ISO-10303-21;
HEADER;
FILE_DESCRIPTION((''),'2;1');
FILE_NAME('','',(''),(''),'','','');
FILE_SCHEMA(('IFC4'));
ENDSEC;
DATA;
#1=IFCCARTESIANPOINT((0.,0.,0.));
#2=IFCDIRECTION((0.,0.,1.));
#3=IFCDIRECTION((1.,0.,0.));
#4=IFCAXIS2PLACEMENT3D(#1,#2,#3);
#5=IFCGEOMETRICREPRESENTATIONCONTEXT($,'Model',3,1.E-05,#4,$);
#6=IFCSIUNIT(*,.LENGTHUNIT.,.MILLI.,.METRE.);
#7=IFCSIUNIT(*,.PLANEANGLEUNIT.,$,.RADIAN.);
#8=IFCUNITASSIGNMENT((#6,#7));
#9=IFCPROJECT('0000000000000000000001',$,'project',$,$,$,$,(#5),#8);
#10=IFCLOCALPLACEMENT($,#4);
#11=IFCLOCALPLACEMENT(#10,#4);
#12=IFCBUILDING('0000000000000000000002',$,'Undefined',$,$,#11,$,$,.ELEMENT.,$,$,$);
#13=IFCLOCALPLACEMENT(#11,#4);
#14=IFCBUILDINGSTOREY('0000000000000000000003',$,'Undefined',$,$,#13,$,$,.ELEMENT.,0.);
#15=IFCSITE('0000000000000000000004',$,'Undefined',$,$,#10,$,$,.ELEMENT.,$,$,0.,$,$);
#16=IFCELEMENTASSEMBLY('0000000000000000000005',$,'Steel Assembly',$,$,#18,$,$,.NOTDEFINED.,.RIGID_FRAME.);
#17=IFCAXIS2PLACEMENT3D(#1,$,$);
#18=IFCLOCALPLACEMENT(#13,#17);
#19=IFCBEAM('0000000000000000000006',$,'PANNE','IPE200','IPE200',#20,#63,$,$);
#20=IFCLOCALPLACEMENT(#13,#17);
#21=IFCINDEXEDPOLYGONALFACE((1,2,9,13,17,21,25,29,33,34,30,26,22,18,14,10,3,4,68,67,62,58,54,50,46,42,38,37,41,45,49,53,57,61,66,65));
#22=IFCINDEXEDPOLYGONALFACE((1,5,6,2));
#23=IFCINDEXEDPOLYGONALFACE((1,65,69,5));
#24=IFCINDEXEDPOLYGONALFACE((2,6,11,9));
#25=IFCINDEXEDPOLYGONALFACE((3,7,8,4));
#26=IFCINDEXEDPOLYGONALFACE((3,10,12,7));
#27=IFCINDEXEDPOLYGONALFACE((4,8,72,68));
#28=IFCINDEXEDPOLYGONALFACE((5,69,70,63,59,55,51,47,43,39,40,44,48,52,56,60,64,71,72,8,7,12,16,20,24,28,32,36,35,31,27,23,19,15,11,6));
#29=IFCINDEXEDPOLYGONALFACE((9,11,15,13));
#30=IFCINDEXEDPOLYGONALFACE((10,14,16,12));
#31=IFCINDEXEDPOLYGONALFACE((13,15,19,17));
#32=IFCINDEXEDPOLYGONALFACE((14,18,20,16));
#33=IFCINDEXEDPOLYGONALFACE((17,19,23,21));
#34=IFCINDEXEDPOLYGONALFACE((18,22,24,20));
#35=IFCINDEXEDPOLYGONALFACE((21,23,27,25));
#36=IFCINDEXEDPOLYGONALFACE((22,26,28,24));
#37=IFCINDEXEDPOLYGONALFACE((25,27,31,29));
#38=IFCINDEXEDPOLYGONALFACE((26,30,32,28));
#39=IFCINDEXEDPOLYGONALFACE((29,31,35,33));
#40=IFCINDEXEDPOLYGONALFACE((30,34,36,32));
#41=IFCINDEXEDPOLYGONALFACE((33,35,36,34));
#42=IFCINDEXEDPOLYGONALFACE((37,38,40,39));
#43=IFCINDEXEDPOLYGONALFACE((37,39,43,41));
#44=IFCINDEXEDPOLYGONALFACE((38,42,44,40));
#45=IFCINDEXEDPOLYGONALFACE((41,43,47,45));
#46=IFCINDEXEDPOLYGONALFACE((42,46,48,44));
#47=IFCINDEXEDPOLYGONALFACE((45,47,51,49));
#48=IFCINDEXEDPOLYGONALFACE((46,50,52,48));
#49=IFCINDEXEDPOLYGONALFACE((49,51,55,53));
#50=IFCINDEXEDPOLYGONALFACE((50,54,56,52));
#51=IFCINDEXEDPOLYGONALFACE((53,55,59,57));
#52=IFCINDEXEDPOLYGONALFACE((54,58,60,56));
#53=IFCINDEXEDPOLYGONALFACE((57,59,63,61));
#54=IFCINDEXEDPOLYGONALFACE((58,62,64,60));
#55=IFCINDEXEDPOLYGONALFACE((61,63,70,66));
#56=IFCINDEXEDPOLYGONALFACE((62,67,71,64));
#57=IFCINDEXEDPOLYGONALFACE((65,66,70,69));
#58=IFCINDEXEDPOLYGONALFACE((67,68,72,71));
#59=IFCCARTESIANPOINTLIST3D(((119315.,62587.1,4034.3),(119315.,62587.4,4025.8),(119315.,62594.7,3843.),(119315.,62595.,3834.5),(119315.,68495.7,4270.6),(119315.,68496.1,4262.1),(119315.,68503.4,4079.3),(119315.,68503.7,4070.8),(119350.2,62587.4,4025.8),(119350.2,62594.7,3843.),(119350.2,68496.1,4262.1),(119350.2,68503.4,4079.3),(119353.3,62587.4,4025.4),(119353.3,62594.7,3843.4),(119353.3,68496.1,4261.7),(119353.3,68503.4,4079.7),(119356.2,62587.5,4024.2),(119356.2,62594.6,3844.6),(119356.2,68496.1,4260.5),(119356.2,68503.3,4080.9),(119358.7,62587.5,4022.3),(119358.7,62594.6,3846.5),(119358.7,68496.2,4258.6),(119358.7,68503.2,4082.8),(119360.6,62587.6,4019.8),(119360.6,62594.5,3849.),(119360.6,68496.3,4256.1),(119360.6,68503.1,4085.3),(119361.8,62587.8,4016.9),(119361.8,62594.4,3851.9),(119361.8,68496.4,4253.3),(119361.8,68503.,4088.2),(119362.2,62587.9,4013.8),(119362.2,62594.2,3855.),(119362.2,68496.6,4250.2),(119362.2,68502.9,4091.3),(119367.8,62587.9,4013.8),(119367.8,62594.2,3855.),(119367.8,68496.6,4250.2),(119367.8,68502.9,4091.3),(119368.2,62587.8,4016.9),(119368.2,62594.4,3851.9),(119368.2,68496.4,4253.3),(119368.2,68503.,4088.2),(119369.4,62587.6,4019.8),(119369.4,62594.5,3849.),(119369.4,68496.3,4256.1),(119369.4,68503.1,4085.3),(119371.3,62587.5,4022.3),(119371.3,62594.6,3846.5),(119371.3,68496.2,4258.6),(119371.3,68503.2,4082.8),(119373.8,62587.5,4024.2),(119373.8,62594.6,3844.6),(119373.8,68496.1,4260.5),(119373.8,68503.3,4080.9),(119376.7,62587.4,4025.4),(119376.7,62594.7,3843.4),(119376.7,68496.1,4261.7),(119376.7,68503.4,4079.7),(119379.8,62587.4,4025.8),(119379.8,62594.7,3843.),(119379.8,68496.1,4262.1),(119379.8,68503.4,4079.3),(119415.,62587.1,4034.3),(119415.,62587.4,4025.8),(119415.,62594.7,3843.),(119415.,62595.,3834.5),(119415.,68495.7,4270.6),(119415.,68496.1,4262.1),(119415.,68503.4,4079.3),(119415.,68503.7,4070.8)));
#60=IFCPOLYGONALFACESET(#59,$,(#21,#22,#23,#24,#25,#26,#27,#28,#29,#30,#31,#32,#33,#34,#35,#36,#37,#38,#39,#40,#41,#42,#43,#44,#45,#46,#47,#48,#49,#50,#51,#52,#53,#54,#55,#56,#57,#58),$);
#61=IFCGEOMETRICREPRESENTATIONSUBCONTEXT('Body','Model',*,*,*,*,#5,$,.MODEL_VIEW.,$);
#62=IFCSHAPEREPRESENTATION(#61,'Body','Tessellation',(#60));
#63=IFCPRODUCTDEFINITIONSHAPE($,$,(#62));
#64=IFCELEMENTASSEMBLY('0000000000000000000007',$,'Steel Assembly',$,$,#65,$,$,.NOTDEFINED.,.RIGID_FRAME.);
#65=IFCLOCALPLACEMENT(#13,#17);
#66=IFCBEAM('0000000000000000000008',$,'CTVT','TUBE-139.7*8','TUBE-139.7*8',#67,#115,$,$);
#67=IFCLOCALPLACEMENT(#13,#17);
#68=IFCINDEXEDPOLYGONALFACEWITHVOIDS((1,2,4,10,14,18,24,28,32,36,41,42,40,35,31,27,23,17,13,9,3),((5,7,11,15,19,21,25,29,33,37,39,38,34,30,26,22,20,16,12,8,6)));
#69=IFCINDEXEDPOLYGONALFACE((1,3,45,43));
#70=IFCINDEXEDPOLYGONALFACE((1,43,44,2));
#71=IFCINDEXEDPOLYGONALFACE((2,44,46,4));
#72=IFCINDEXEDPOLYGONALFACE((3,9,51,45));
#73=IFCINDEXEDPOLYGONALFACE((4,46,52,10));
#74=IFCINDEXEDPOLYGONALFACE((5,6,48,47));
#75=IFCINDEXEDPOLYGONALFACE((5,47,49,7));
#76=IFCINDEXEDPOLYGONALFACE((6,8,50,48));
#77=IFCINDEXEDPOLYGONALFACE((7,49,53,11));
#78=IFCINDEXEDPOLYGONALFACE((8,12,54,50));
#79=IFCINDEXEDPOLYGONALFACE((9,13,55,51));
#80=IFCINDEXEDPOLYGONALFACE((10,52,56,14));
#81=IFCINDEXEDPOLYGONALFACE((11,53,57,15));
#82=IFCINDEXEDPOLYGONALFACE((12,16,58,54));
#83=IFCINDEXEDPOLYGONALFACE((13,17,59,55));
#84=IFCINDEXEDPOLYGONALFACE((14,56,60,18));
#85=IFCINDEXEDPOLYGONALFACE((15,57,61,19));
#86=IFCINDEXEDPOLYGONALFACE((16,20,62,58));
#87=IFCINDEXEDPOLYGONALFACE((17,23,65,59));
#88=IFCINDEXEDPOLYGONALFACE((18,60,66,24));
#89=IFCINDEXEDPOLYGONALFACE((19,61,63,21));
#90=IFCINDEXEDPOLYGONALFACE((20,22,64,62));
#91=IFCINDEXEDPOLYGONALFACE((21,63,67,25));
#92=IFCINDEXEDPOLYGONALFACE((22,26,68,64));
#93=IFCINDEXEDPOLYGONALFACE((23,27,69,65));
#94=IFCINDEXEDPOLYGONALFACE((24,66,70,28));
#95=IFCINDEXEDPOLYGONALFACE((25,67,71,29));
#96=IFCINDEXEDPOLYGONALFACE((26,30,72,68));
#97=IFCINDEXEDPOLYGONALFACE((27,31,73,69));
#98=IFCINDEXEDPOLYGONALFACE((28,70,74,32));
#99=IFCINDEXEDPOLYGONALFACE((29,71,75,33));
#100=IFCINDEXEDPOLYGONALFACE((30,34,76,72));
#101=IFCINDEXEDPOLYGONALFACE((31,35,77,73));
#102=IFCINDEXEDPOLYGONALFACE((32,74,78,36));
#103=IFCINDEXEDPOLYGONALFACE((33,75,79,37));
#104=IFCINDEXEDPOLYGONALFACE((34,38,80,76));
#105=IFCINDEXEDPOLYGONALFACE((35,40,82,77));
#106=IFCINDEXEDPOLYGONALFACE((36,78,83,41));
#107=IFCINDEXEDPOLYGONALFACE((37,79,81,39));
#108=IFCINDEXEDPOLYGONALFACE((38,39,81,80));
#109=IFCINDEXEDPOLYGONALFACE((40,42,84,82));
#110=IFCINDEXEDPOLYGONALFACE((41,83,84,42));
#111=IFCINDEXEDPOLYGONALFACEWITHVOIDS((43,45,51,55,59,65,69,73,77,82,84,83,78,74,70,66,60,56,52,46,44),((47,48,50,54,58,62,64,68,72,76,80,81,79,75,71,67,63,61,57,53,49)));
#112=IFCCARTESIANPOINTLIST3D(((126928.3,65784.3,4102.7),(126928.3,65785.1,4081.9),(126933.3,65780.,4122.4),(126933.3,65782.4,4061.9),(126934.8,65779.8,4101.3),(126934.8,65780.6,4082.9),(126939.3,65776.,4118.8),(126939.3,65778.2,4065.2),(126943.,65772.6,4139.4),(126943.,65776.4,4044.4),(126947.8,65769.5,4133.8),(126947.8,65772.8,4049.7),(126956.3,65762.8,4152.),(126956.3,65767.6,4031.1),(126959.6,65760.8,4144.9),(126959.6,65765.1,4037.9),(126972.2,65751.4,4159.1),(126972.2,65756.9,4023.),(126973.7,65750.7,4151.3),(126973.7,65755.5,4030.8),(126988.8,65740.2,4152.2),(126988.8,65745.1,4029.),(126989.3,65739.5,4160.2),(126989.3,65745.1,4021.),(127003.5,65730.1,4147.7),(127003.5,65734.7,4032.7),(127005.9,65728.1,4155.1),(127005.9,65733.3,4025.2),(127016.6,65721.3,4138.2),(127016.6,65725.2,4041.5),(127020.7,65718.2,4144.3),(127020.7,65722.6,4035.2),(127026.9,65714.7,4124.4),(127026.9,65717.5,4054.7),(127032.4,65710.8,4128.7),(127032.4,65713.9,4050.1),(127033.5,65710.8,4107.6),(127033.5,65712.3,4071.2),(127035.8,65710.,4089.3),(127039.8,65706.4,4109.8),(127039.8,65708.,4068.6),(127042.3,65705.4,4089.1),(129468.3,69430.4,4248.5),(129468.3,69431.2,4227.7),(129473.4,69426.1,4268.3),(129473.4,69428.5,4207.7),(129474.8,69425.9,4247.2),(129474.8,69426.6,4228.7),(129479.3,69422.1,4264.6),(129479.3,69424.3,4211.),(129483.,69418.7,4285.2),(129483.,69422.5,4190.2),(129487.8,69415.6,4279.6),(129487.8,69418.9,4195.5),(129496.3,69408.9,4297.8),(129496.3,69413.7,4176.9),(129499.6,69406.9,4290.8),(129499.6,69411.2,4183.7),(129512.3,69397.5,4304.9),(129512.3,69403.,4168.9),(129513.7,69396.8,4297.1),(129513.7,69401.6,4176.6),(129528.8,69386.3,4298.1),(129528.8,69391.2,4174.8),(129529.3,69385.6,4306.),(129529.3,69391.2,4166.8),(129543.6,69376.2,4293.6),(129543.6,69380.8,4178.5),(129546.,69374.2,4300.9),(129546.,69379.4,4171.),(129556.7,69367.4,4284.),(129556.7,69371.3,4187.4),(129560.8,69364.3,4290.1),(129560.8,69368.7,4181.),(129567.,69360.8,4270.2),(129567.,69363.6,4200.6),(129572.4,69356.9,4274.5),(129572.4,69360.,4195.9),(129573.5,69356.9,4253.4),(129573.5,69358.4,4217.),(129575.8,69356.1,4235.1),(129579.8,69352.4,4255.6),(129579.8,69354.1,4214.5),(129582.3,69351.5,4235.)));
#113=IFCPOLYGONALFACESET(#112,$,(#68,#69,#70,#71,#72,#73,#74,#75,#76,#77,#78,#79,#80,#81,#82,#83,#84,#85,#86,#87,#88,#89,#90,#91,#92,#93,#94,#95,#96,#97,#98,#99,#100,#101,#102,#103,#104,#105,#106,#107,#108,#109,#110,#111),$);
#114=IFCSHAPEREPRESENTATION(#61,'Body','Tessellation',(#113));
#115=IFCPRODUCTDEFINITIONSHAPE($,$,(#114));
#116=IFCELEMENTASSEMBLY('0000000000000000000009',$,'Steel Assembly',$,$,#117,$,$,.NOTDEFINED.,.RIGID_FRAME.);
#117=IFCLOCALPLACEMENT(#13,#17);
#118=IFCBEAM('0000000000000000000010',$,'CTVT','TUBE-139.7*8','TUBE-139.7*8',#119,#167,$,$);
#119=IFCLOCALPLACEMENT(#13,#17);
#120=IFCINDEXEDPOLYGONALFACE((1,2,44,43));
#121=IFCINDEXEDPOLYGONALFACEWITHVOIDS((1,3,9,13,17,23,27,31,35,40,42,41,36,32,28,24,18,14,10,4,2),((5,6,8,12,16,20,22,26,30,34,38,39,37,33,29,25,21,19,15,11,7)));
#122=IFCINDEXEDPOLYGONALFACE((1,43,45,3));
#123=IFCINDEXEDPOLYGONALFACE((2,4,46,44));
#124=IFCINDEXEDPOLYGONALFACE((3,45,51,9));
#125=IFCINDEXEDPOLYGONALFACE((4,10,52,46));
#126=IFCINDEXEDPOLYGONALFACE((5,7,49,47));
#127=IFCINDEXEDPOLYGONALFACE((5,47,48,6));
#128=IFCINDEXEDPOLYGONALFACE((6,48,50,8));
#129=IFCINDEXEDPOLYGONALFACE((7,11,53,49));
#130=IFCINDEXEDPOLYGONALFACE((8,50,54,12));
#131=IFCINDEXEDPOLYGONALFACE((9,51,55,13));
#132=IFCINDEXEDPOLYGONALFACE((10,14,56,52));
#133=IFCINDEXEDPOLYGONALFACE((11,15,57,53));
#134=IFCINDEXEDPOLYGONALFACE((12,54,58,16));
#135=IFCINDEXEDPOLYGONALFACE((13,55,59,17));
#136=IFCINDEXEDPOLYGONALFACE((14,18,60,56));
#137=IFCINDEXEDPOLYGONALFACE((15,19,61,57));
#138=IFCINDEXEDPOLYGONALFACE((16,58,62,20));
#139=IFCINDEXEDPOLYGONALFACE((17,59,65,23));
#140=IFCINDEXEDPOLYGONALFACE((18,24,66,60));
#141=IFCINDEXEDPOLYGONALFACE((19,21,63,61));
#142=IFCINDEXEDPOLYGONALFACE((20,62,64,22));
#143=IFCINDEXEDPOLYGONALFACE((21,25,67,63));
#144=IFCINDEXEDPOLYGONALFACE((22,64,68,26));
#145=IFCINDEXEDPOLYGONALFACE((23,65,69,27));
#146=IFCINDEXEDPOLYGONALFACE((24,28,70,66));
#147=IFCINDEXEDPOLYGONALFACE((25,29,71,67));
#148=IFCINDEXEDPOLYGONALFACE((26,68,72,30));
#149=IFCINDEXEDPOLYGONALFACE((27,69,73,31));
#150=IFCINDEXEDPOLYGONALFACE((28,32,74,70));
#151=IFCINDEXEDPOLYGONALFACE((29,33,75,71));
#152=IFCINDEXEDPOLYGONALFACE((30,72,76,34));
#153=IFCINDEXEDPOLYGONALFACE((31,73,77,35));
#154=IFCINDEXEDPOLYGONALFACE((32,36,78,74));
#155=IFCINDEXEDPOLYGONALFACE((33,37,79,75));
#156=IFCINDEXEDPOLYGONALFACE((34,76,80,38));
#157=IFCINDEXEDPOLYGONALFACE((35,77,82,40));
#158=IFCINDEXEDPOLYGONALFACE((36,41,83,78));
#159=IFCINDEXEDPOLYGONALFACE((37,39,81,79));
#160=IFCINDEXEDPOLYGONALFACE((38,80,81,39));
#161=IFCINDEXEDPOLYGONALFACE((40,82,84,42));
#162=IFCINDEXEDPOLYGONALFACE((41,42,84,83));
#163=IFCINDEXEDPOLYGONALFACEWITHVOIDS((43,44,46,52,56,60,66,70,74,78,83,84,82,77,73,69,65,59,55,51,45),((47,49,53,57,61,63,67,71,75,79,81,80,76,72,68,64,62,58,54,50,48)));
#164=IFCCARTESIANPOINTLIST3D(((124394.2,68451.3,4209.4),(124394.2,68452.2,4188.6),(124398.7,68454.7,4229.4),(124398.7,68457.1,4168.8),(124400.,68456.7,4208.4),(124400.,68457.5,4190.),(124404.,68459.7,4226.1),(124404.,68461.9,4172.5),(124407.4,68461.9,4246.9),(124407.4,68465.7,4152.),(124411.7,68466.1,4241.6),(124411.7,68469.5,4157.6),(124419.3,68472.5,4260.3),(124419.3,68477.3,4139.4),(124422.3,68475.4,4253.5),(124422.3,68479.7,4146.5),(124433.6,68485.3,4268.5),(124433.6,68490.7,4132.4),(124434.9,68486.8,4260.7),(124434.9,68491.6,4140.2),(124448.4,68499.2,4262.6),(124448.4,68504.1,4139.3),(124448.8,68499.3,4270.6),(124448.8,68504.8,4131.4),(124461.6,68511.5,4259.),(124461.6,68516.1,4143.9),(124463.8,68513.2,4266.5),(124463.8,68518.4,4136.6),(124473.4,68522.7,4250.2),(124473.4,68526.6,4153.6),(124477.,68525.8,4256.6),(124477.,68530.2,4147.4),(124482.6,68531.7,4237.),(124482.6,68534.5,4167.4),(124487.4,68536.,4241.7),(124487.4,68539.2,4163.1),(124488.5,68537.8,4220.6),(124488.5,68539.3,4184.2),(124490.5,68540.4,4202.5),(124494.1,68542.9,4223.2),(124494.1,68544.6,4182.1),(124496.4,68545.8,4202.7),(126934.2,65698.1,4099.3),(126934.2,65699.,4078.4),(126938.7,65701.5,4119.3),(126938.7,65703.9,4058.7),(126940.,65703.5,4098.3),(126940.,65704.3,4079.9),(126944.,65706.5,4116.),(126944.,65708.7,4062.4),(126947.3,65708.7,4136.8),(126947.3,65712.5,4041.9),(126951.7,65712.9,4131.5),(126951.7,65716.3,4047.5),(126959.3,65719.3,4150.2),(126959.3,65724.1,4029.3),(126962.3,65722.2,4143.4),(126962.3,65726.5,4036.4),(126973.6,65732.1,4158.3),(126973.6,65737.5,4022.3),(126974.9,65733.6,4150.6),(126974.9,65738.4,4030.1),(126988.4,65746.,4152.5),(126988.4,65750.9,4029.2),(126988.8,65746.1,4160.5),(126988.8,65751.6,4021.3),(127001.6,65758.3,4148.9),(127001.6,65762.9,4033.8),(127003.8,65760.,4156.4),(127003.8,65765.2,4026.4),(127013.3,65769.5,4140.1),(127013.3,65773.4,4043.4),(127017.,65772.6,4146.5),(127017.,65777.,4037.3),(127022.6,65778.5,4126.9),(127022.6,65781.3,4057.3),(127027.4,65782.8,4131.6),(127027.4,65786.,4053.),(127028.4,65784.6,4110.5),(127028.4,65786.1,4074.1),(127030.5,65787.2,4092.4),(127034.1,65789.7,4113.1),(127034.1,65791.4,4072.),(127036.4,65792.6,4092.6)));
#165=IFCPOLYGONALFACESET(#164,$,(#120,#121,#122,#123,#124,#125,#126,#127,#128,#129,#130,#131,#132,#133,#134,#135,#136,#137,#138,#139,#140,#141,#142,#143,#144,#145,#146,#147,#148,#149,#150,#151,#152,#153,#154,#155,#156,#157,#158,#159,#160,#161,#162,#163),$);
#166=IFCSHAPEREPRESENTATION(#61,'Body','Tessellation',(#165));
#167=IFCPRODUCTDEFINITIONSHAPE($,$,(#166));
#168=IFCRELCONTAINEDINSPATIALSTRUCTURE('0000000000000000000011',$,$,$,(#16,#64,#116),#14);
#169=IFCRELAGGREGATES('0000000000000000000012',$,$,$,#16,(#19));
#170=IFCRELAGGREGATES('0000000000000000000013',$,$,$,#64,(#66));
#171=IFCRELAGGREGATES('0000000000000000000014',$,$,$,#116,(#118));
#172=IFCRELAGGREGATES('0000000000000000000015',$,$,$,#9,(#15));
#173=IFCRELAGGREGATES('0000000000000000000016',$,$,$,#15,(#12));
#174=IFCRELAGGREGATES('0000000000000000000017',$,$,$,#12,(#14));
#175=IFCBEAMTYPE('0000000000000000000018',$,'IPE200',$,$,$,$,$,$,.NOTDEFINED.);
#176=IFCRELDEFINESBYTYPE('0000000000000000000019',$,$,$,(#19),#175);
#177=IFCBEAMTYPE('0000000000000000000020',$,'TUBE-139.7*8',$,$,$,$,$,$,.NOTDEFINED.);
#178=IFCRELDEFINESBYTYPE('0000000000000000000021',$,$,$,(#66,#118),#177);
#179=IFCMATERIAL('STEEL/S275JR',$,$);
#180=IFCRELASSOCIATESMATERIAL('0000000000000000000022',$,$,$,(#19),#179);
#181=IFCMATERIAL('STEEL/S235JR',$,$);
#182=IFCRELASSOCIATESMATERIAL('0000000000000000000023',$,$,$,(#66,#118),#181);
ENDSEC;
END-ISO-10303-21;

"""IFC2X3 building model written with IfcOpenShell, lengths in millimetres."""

from ifc_helpers import new_model, si_unit, frame, origin_with_axes, origin_2d_with_axis, place, context, subcontext, project, spatial, hollow_circle, i_section, extrude, material, type_object, element, aggregate, save


model = new_model("IFC2X3")

# Units and contexts
model_context = context("Model", 3, precision=1e-05, world=origin_with_axes())
body_context = subcontext(model_context, "Body", "Model", "MODEL_VIEW")
ifc_project = project(units=[si_unit("LENGTHUNIT", "METRE", prefix="MILLI"), si_unit("PLANEANGLEUNIT", "RADIAN")], contexts=[model_context])

# Site, building, storey
site_placement = place(None, origin_with_axes())
site = spatial("IfcSite", under=ifc_project, at=site_placement, Name="Undefined", CompositionType="ELEMENT", RefElevation=0.0)
building_placement = place(site_placement, origin_with_axes())
building = spatial("IfcBuilding", under=site, at=building_placement, Name="Undefined", CompositionType="ELEMENT")
storey_placement = place(building_placement, origin_with_axes())
storey = spatial("IfcBuildingStorey", under=building, at=storey_placement, Name="Undefined", CompositionType="ELEMENT", Elevation=0.0)

# Element assemblies, beams
assembly_1_placement = place(storey_placement, origin_with_axes())
assembly_1 = element("IfcElementAssembly", 1, at=assembly_1_placement, inside=storey, Name="Steel Assembly", AssemblyPlace="NOTDEFINED", PredefinedType="RIGID_FRAME")
ifc_material_1 = material(Name="STEEL/S275JR")
beam_type_1 = type_object("IfcBeamType", Name="IPE200", PredefinedType="NOTDEFINED")
beam_1_placement = place(assembly_1_placement, frame((119365.0, 62591.1, 3934.4), z_axis=(0.0, -0.039962, 0.999201), x_axis=(0.0, 0.999201, 0.039962)))
beam_1 = element("IfcBeam", 2, at=beam_1_placement, type_object=beam_type_1, material=ifc_material_1, Name="PANNE", Description="IPE200", ObjectType="IPE200", context=body_context, shape_type="SweptSolid", body=[
    extrude(i_section(OverallWidth=100.0, OverallDepth=200.0, WebThickness=5.6, FlangeThickness=8.5, FilletRadius=12.0, at=origin_2d_with_axis()), frame((5913.4, 0.0, 0.0), z_axis=(-1.0, 0.0, 0.0), x_axis=(0.0, -1.0, 0.0)), (0.0, 0.0, 1.0), 5913.4),
])
aggregate(assembly_1, [beam_1])
assembly_2_placement = place(storey_placement, origin_with_axes())
assembly_2 = element("IfcElementAssembly", 3, at=assembly_2_placement, inside=storey, Name="Steel Assembly", AssemblyPlace="NOTDEFINED", PredefinedType="RIGID_FRAME")
ifc_material_2 = material(Name="STEEL/S235JR")
beam_type_2 = type_object("IfcBeamType", Name="TUBE-139.7*8", PredefinedType="NOTDEFINED")
beam_2_placement = place(assembly_2_placement, frame((126985.0, 65745.3, 4090.7), z_axis=(-0.000002, -0.039963, 0.999201), x_axis=(0.571304, 0.820083, 0.0328)))
beam_2 = element("IfcBeam", 4, at=beam_2_placement, type_object=beam_type_2, material=ifc_material_2, Name="CTVT", Description="TUBE-139.7*8", ObjectType="TUBE-139.7*8", context=body_context, shape_type="SweptSolid", body=[
    extrude(hollow_circle(Radius=69.8, WallThickness=8.0, at=origin_2d_with_axis()), frame((4446.0, 0.0, 0.0), z_axis=(-1.0, 0.0, 0.0), x_axis=(0.0, -1.0, 0.0)), (0.0, 0.0, 1.0), 4446.0),
])
aggregate(assembly_2, [beam_2])
assembly_3_placement = place(storey_placement, origin_with_axes())
assembly_3 = element("IfcElementAssembly", 5, at=assembly_3_placement, inside=storey, Name="Steel Assembly", AssemblyPlace="NOTDEFINED", PredefinedType="RIGID_FRAME")
beam_3_placement = place(assembly_3_placement, frame((126985.0, 65745.3, 4090.7), z_axis=(-0.000001, -0.039961, 0.999201), x_axis=(-0.677781, 0.734677, 0.029382)))
beam_3 = element("IfcBeam", 6, at=beam_3_placement, type_object=beam_type_2, material=ifc_material_2, Name="CTVT", Description="TUBE-139.7*8", ObjectType="TUBE-139.7*8", context=body_context, shape_type="SweptSolid", body=[
    extrude(hollow_circle(Radius=69.8, WallThickness=8.0, at=origin_2d_with_axis()), frame((3747.5, 0.0, 0.0), z_axis=(-1.0, 0.0, 0.0), x_axis=(0.0, -1.0, 0.0)), (0.0, 0.0, 1.0), 3747.5),
])
aggregate(assembly_3, [beam_3])

save(model, "model.ifc")
